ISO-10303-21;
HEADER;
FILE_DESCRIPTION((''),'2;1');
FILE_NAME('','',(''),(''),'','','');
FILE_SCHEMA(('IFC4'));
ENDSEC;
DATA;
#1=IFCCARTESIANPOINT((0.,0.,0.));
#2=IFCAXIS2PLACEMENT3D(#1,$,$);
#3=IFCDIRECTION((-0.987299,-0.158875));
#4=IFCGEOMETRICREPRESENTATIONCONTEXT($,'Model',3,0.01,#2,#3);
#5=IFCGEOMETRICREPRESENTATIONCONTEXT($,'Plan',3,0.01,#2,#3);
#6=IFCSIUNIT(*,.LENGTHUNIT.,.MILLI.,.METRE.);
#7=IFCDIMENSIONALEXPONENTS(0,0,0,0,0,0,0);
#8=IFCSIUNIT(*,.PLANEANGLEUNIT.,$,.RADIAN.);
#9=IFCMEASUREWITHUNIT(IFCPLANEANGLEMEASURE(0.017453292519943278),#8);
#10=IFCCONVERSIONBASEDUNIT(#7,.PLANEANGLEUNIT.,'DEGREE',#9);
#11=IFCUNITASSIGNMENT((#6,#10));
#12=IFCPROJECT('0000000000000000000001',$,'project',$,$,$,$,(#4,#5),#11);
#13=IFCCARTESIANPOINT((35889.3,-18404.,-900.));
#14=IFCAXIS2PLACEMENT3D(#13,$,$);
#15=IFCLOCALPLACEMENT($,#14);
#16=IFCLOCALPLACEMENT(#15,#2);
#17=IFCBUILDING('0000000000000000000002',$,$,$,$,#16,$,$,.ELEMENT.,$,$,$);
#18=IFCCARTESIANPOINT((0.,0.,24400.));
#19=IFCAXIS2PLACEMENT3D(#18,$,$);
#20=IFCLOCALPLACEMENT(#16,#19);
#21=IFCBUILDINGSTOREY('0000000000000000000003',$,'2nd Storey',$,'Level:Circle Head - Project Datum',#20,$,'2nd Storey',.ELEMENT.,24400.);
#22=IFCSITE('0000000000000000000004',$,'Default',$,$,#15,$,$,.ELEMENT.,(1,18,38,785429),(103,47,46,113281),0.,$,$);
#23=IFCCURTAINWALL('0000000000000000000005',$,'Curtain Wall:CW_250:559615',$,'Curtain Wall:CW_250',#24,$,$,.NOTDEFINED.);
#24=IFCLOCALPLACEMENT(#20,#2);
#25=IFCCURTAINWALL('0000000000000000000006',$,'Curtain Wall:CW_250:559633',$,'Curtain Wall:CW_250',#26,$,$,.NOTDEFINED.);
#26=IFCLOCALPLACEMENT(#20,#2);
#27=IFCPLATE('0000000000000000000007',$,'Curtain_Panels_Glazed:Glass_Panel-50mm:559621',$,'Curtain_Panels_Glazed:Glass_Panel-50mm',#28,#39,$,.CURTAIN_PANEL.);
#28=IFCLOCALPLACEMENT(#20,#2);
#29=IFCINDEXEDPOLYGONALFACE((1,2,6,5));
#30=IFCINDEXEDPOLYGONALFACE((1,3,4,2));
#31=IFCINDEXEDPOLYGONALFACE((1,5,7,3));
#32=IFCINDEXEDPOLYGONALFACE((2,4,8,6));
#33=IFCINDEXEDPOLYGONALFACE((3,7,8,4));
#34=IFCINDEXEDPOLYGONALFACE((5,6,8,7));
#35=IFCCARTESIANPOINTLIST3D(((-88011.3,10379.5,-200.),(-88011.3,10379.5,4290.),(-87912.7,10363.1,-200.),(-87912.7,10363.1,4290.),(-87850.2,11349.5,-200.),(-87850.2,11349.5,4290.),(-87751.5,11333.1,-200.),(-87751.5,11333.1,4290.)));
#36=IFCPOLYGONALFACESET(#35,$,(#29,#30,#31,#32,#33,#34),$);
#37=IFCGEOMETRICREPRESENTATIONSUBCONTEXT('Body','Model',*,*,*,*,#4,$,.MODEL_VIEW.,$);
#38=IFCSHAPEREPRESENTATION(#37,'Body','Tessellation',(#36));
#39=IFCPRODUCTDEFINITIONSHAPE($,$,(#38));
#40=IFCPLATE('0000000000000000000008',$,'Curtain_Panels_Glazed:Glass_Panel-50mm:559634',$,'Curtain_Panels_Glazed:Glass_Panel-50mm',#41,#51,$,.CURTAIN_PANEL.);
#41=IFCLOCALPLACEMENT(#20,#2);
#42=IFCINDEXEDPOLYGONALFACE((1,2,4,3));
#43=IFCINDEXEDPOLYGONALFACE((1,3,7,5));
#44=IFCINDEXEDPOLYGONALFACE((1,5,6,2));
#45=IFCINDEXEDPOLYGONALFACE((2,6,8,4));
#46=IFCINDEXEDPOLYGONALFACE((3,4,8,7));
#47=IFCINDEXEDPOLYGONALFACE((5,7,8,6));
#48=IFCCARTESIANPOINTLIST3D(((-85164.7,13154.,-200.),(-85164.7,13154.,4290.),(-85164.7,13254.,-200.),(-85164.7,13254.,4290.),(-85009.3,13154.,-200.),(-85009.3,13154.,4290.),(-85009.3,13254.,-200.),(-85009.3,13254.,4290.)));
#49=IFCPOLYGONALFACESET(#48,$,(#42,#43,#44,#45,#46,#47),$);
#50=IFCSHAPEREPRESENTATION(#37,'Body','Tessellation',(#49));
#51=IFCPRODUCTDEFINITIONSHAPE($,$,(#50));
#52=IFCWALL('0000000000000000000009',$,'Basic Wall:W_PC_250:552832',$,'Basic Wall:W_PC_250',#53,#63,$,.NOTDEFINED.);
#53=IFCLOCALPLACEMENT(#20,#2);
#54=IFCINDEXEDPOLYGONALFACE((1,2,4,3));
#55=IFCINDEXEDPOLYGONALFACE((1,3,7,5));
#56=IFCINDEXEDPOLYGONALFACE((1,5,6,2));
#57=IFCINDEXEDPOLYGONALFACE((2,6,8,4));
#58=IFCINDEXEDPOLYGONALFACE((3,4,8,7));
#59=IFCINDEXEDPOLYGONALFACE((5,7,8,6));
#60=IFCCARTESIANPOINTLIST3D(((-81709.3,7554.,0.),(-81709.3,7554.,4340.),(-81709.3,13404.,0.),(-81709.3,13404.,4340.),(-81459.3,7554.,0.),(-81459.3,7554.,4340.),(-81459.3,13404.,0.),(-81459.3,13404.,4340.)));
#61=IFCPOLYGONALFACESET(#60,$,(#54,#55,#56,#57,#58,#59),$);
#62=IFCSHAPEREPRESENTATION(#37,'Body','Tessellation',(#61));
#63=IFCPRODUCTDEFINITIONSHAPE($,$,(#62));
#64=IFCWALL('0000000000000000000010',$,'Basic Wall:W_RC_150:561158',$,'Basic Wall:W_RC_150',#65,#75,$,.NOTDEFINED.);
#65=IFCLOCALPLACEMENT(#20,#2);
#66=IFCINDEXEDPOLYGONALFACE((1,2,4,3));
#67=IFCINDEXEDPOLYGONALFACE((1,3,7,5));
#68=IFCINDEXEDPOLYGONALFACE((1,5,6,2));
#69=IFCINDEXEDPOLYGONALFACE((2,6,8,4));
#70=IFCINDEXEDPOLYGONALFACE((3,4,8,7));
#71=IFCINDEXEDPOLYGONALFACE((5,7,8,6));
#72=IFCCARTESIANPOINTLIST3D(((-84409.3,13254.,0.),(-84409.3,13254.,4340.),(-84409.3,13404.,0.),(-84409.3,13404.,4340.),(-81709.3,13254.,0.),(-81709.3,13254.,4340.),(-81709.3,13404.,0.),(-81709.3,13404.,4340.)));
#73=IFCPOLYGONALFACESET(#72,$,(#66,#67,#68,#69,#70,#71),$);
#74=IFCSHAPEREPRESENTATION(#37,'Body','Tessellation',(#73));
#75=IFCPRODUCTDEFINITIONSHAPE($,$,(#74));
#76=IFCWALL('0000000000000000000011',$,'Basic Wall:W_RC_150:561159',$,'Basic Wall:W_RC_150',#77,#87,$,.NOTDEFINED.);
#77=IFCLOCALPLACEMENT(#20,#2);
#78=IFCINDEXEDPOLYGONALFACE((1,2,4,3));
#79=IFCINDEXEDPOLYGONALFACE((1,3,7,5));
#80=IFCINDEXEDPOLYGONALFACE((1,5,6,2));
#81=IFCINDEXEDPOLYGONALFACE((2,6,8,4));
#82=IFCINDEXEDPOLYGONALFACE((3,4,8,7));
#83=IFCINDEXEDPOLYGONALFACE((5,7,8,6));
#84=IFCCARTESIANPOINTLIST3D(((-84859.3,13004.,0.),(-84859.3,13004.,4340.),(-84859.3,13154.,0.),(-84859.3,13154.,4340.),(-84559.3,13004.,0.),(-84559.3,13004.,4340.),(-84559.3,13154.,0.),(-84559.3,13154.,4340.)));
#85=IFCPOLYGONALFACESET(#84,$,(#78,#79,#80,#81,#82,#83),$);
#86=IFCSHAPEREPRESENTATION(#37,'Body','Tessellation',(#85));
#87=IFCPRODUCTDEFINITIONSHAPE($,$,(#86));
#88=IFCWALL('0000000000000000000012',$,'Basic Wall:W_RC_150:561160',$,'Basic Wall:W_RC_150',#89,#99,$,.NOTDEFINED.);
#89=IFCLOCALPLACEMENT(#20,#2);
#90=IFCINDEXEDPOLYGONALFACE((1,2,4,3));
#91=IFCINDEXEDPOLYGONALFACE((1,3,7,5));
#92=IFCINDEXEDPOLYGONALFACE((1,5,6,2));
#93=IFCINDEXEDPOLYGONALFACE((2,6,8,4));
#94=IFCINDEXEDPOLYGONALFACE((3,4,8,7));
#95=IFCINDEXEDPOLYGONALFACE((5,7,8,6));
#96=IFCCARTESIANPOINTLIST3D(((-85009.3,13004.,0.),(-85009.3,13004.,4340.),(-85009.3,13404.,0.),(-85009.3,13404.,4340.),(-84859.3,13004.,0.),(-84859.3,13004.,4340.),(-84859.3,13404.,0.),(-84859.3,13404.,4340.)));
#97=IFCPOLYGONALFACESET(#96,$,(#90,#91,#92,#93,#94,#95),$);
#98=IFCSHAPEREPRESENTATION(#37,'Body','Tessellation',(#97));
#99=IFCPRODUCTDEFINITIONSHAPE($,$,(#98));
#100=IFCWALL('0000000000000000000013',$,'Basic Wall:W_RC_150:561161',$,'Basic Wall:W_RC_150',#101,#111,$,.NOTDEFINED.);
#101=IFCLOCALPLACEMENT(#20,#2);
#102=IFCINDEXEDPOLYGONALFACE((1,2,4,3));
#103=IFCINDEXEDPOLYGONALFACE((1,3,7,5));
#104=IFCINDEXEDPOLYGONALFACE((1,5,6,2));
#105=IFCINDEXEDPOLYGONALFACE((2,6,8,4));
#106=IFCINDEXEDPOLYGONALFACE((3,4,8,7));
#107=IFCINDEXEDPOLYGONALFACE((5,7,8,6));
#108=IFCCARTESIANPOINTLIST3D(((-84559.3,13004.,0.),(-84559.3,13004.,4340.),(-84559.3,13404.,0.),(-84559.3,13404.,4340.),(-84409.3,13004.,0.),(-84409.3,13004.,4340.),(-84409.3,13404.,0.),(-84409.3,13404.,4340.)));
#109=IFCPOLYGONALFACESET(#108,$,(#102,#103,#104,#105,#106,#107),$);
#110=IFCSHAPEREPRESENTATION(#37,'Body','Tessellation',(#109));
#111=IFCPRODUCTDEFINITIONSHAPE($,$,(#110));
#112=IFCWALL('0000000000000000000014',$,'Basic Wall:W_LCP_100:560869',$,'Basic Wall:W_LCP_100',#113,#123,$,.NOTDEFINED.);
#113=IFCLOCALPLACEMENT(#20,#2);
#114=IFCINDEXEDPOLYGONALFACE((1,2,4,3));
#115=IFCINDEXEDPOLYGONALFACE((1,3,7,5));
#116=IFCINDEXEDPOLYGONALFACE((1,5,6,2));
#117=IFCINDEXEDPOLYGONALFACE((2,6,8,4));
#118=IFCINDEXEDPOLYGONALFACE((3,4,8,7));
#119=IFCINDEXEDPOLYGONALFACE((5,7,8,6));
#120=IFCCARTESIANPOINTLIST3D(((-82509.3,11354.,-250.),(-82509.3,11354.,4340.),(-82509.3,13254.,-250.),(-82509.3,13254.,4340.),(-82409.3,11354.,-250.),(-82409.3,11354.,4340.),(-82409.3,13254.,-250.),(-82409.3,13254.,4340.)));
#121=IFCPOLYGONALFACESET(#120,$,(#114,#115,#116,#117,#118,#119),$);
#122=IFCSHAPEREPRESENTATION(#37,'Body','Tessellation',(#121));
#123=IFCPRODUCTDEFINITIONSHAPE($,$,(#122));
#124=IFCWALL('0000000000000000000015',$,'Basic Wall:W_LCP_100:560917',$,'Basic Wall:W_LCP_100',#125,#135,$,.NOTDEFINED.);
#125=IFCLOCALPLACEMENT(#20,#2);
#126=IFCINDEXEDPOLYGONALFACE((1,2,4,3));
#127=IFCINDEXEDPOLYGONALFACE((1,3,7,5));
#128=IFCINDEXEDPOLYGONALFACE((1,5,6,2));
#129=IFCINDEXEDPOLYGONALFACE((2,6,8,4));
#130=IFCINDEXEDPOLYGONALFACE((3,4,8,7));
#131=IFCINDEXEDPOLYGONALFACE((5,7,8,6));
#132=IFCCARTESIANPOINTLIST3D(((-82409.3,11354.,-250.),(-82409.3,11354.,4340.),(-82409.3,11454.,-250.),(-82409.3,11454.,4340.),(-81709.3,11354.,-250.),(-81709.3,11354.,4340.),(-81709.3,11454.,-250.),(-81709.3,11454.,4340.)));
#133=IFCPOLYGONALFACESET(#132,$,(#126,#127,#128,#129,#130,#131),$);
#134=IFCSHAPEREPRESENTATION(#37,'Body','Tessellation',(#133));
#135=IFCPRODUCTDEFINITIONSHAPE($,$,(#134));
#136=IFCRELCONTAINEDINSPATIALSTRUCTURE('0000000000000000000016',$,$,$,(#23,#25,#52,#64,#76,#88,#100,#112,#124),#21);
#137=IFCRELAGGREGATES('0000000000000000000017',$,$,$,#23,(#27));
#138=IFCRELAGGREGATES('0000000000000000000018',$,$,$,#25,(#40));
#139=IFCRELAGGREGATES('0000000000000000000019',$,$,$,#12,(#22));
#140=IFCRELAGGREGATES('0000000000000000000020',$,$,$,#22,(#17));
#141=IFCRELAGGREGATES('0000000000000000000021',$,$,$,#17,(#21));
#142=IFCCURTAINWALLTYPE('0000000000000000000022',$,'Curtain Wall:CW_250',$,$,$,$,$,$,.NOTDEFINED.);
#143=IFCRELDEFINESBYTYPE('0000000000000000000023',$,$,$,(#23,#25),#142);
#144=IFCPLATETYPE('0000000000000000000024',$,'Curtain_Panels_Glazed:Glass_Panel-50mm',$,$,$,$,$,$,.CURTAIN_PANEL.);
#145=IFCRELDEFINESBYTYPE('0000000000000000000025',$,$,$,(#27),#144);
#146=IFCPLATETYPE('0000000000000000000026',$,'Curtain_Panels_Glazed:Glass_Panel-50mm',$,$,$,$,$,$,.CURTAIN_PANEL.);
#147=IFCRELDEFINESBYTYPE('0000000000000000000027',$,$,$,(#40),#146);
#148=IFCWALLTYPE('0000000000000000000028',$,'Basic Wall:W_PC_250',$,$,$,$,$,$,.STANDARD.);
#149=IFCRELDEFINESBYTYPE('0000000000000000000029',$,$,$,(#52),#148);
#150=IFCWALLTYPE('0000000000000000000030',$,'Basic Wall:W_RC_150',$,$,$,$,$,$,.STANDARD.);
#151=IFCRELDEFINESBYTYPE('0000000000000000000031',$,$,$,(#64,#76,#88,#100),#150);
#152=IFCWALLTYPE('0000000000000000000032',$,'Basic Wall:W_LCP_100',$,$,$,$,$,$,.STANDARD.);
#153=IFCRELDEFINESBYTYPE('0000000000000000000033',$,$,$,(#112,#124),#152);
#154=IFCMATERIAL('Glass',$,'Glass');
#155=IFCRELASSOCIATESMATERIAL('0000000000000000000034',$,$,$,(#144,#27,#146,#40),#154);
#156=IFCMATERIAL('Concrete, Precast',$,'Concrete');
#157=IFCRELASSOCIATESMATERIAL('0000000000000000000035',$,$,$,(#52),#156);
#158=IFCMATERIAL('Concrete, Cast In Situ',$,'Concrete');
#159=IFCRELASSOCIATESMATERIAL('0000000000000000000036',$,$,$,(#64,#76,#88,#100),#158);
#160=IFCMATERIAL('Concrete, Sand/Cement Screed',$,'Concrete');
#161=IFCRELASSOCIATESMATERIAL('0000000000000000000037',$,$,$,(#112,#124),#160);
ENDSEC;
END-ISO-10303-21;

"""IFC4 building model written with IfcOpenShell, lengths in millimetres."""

from ifc_helpers import new_model, entity, si_unit, converted_unit, direction, frame, origin, place, context, subcontext, project, spatial, indexed_curve, outline, extrude, source, transform, mapped, material, type_object, type_shapes, element, aggregate, save


model = new_model("IFC4")

# Units and contexts
model_context = context("Model", 3, precision=0.01, world=origin(), true_north=direction((-0.987299, -0.158875)))
plan_context = context("Plan", 3, precision=0.01, world=origin(), true_north=direction((-0.987299, -0.158875)))
body_context = subcontext(model_context, "Body", "Model", "MODEL_VIEW")
ifc_project = project(units=[si_unit("LENGTHUNIT", "METRE", prefix="MILLI"), converted_unit("PLANEANGLEUNIT", "DEGREE", entity("IfcPlaneAngleMeasure", 0.017453292519943278), si_unit("PLANEANGLEUNIT", "RADIAN"), dimensions=[0, 0, 0, 0, 0, 0, 0])], contexts=[model_context, plan_context])

# Site, building, storey
site_placement = place(None, frame((35889.3, -18404.0, -900.0)))
site = spatial("IfcSite", under=ifc_project, at=site_placement, Name="Default", CompositionType="ELEMENT", RefLatitude=(1, 18, 38, 785429), RefLongitude=(103, 47, 46, 113281), RefElevation=0.0)
building_placement = place(site_placement, origin())
building = spatial("IfcBuilding", under=site, at=building_placement, CompositionType="ELEMENT")
storey_placement = place(building_placement, frame((0.0, 0.0, 24400.0)))
storey = spatial("IfcBuildingStorey", under=building, at=storey_placement, Name="2nd Storey", ObjectType="Level:Circle Head - Project Datum", LongName="2nd Storey", CompositionType="ELEMENT", Elevation=24400.0)

# Curtain walls
curtain_wall_type = type_object("IfcCurtainWallType", Name="Curtain Wall:CW_250", PredefinedType="NOTDEFINED")
curtain_wall_1_placement = place(storey_placement, frame((0.0, 0.0, -24400.0)))
curtain_wall_1 = element("IfcCurtainWall", 1, at=curtain_wall_1_placement, inside=storey, type_object=curtain_wall_type, Name="Curtain Wall:CW_250:559615", ObjectType="Curtain Wall:CW_250", PredefinedType="NOTDEFINED")
curtain_wall_2_placement = place(storey_placement, frame((0.0, 0.0, -24400.0)))
curtain_wall_2 = element("IfcCurtainWall", 2, at=curtain_wall_2_placement, inside=storey, type_object=curtain_wall_type, Name="Curtain Wall:CW_250:559633", ObjectType="Curtain Wall:CW_250", PredefinedType="NOTDEFINED")

# Plates
ifc_material_1 = material(Name="Glass", Category="Glass")
plate_type_1 = type_object("IfcPlateType", Name="Curtain_Panels_Glazed:Glass_Panel-50mm", PredefinedType="CURTAIN_PANEL", material=ifc_material_1)
shared_shape_1 = source(origin(), body_context, "Body", "SweptSolid", [
    extrude(outline(indexed_curve([(-50.0, -491.6), (50.0, -491.6), (50.0, 491.6), (-50.0, 491.6), (-50.0, -491.6)], self_intersect=False)), frame((0.0, 200.0, 0.0), z_axis=(0.0, 0.0, 1.0), x_axis=(0.0, 1.0, 0.0)), (0.0, 0.0, 1.0), 4490.0),
])
type_shapes(plate_type_1, [shared_shape_1])
plate_1_placement = place(curtain_wall_1_placement, frame((-88078.7, 10889.0, 24200.0), z_axis=(0.0, 0.0, 1.0), x_axis=(-0.163882, -0.98648, 0.0)))
plate_1 = element("IfcPlate", 3, at=plate_1_placement, type_object=plate_type_1, material=ifc_material_1, Name="Curtain_Panels_Glazed:Glass_Panel-50mm:559621", ObjectType="Curtain_Panels_Glazed:Glass_Panel-50mm", PredefinedType="CURTAIN_PANEL", context=body_context, shape_type="MappedRepresentation", body=[
    mapped(shared_shape_1, transform((0.0, 0.0, 0.0), scale=1.0)),
])
aggregate(curtain_wall_1, [plate_1])
plate_type_2 = type_object("IfcPlateType", Name="Curtain_Panels_Glazed:Glass_Panel-50mm", PredefinedType="CURTAIN_PANEL", material=ifc_material_1)
shared_shape_2 = source(origin(), body_context, "Body", "SweptSolid", [
    extrude(outline(indexed_curve([(-50.0, -77.7), (50.0, -77.7), (50.0, 77.7), (-50.0, 77.7), (-50.0, -77.7)], self_intersect=False)), frame((0.0, 200.0, 0.0), z_axis=(0.0, 0.0, 1.0), x_axis=(0.0, 1.0, 0.0)), (0.0, 0.0, 1.0), 4490.0),
])
type_shapes(plate_type_2, [shared_shape_2])
plate_2_placement = place(curtain_wall_2_placement, frame((-85087.0, 13404.0, 24200.0), z_axis=(0.0, 0.0, 1.0), x_axis=(-1.0, 0.0, 0.0)))
plate_2 = element("IfcPlate", 4, at=plate_2_placement, type_object=plate_type_2, material=ifc_material_1, Name="Curtain_Panels_Glazed:Glass_Panel-50mm:559634", ObjectType="Curtain_Panels_Glazed:Glass_Panel-50mm", PredefinedType="CURTAIN_PANEL", context=body_context, shape_type="MappedRepresentation", body=[
    mapped(shared_shape_2, transform((0.0, 0.0, 0.0), scale=1.0)),
])
aggregate(curtain_wall_2, [plate_2])

# Walls
ifc_material_2 = material(Name="Concrete, Precast", Category="Concrete")
wall_type_1 = type_object("IfcWallType", Name="Basic Wall:W_PC_250", PredefinedType="STANDARD")
wall_1_placement = place(storey_placement, frame((-81584.3, 7554.0, 0.0), z_axis=(0.0, 0.0, 1.0), x_axis=(0.0, 1.0, 0.0)))
element("IfcWall", 5, at=wall_1_placement, inside=storey, type_object=wall_type_1, material=ifc_material_2, Name="Basic Wall:W_PC_250:552832", ObjectType="Basic Wall:W_PC_250", PredefinedType="NOTDEFINED", context=body_context, shape_type="SweptSolid", body=[
    extrude(outline(indexed_curve([(5850.0, 125.0), (0.0, 125.0), (0.0, -125.0), (5850.0, -125.0), (5850.0, 125.0)], self_intersect=False)), origin(), (0.0, 0.0, 1.0), 4340.0),
])
ifc_material_3 = material(Name="Concrete, Cast In Situ", Category="Concrete")
wall_type_2 = type_object("IfcWallType", Name="Basic Wall:W_RC_150", PredefinedType="STANDARD")
wall_2_placement = place(storey_placement, frame((-81709.3, 13329.0, 0.0), z_axis=(0.0, 0.0, 1.0), x_axis=(-1.0, 0.0, 0.0)))
element("IfcWall", 6, at=wall_2_placement, inside=storey, type_object=wall_type_2, material=ifc_material_3, Name="Basic Wall:W_RC_150:561158", ObjectType="Basic Wall:W_RC_150", PredefinedType="NOTDEFINED", context=body_context, shape_type="SweptSolid", body=[
    extrude(outline(indexed_curve([(2700.0, 75.0), (0.0, 75.0), (0.0, -75.0), (2700.0, -75.0), (2700.0, 75.0)], self_intersect=False)), origin(), (0.0, 0.0, 1.0), 4340.0),
])
wall_3_placement = place(storey_placement, frame((-84559.3, 13079.0, 0.0), z_axis=(0.0, 0.0, 1.0), x_axis=(-1.0, 0.0, 0.0)))
element("IfcWall", 7, at=wall_3_placement, inside=storey, type_object=wall_type_2, material=ifc_material_3, Name="Basic Wall:W_RC_150:561159", ObjectType="Basic Wall:W_RC_150", PredefinedType="NOTDEFINED", context=body_context, shape_type="SweptSolid", body=[
    extrude(outline(indexed_curve([(300.0, 75.0), (0.0, 75.0), (0.0, -75.0), (300.0, -75.0), (300.0, 75.0)], self_intersect=False)), origin(), (0.0, 0.0, 1.0), 4340.0),
])
wall_4_placement = place(storey_placement, frame((-84934.3, 13004.0, 0.0), z_axis=(0.0, 0.0, 1.0), x_axis=(0.0, 1.0, 0.0)))
element("IfcWall", 8, at=wall_4_placement, inside=storey, type_object=wall_type_2, material=ifc_material_3, Name="Basic Wall:W_RC_150:561160", ObjectType="Basic Wall:W_RC_150", PredefinedType="NOTDEFINED", context=body_context, shape_type="SweptSolid", body=[
    extrude(outline(indexed_curve([(400.0, 75.0), (0.0, 75.0), (0.0, -75.0), (400.0, -75.0), (400.0, 75.0)], self_intersect=False)), origin(), (0.0, 0.0, 1.0), 4340.0),
])
wall_5_placement = place(storey_placement, frame((-84484.3, 13004.0, 0.0), z_axis=(0.0, 0.0, 1.0), x_axis=(0.0, 1.0, 0.0)))
element("IfcWall", 9, at=wall_5_placement, inside=storey, type_object=wall_type_2, material=ifc_material_3, Name="Basic Wall:W_RC_150:561161", ObjectType="Basic Wall:W_RC_150", PredefinedType="NOTDEFINED", context=body_context, shape_type="SweptSolid", body=[
    extrude(outline(indexed_curve([(400.0, 75.0), (0.0, 75.0), (0.0, -75.0), (400.0, -75.0), (400.0, 75.0)], self_intersect=False)), origin(), (0.0, 0.0, 1.0), 4340.0),
])
ifc_material_4 = material(Name="Concrete, Sand/Cement Screed", Category="Concrete")
wall_type_3 = type_object("IfcWallType", Name="Basic Wall:W_LCP_100", PredefinedType="STANDARD")
wall_6_placement = place(storey_placement, frame((-82459.3, 13254.0, -250.0), z_axis=(0.0, 0.0, 1.0), x_axis=(0.0, -1.0, 0.0)))
element("IfcWall", 10, at=wall_6_placement, inside=storey, type_object=wall_type_3, material=ifc_material_4, Name="Basic Wall:W_LCP_100:560869", ObjectType="Basic Wall:W_LCP_100", PredefinedType="NOTDEFINED", context=body_context, shape_type="SweptSolid", body=[
    extrude(outline(indexed_curve([(1900.0, 50.0), (0.0, 50.0), (0.0, -50.0), (1900.0, -50.0), (1900.0, 50.0)], self_intersect=False)), origin(), (0.0, 0.0, 1.0), 4590.0),
])
wall_7_placement = place(storey_placement, frame((-81709.3, 11404.0, -250.0), z_axis=(0.0, 0.0, 1.0), x_axis=(-1.0, 0.0, 0.0)))
element("IfcWall", 11, at=wall_7_placement, inside=storey, type_object=wall_type_3, material=ifc_material_4, Name="Basic Wall:W_LCP_100:560917", ObjectType="Basic Wall:W_LCP_100", PredefinedType="NOTDEFINED", context=body_context, shape_type="SweptSolid", body=[
    extrude(outline(indexed_curve([(700.0, 50.0), (0.0, 50.0), (0.0, -50.0), (700.0, -50.0), (700.0, 50.0)], self_intersect=False)), origin(), (0.0, 0.0, 1.0), 4590.0),
])

save(model, "model.ifc")
